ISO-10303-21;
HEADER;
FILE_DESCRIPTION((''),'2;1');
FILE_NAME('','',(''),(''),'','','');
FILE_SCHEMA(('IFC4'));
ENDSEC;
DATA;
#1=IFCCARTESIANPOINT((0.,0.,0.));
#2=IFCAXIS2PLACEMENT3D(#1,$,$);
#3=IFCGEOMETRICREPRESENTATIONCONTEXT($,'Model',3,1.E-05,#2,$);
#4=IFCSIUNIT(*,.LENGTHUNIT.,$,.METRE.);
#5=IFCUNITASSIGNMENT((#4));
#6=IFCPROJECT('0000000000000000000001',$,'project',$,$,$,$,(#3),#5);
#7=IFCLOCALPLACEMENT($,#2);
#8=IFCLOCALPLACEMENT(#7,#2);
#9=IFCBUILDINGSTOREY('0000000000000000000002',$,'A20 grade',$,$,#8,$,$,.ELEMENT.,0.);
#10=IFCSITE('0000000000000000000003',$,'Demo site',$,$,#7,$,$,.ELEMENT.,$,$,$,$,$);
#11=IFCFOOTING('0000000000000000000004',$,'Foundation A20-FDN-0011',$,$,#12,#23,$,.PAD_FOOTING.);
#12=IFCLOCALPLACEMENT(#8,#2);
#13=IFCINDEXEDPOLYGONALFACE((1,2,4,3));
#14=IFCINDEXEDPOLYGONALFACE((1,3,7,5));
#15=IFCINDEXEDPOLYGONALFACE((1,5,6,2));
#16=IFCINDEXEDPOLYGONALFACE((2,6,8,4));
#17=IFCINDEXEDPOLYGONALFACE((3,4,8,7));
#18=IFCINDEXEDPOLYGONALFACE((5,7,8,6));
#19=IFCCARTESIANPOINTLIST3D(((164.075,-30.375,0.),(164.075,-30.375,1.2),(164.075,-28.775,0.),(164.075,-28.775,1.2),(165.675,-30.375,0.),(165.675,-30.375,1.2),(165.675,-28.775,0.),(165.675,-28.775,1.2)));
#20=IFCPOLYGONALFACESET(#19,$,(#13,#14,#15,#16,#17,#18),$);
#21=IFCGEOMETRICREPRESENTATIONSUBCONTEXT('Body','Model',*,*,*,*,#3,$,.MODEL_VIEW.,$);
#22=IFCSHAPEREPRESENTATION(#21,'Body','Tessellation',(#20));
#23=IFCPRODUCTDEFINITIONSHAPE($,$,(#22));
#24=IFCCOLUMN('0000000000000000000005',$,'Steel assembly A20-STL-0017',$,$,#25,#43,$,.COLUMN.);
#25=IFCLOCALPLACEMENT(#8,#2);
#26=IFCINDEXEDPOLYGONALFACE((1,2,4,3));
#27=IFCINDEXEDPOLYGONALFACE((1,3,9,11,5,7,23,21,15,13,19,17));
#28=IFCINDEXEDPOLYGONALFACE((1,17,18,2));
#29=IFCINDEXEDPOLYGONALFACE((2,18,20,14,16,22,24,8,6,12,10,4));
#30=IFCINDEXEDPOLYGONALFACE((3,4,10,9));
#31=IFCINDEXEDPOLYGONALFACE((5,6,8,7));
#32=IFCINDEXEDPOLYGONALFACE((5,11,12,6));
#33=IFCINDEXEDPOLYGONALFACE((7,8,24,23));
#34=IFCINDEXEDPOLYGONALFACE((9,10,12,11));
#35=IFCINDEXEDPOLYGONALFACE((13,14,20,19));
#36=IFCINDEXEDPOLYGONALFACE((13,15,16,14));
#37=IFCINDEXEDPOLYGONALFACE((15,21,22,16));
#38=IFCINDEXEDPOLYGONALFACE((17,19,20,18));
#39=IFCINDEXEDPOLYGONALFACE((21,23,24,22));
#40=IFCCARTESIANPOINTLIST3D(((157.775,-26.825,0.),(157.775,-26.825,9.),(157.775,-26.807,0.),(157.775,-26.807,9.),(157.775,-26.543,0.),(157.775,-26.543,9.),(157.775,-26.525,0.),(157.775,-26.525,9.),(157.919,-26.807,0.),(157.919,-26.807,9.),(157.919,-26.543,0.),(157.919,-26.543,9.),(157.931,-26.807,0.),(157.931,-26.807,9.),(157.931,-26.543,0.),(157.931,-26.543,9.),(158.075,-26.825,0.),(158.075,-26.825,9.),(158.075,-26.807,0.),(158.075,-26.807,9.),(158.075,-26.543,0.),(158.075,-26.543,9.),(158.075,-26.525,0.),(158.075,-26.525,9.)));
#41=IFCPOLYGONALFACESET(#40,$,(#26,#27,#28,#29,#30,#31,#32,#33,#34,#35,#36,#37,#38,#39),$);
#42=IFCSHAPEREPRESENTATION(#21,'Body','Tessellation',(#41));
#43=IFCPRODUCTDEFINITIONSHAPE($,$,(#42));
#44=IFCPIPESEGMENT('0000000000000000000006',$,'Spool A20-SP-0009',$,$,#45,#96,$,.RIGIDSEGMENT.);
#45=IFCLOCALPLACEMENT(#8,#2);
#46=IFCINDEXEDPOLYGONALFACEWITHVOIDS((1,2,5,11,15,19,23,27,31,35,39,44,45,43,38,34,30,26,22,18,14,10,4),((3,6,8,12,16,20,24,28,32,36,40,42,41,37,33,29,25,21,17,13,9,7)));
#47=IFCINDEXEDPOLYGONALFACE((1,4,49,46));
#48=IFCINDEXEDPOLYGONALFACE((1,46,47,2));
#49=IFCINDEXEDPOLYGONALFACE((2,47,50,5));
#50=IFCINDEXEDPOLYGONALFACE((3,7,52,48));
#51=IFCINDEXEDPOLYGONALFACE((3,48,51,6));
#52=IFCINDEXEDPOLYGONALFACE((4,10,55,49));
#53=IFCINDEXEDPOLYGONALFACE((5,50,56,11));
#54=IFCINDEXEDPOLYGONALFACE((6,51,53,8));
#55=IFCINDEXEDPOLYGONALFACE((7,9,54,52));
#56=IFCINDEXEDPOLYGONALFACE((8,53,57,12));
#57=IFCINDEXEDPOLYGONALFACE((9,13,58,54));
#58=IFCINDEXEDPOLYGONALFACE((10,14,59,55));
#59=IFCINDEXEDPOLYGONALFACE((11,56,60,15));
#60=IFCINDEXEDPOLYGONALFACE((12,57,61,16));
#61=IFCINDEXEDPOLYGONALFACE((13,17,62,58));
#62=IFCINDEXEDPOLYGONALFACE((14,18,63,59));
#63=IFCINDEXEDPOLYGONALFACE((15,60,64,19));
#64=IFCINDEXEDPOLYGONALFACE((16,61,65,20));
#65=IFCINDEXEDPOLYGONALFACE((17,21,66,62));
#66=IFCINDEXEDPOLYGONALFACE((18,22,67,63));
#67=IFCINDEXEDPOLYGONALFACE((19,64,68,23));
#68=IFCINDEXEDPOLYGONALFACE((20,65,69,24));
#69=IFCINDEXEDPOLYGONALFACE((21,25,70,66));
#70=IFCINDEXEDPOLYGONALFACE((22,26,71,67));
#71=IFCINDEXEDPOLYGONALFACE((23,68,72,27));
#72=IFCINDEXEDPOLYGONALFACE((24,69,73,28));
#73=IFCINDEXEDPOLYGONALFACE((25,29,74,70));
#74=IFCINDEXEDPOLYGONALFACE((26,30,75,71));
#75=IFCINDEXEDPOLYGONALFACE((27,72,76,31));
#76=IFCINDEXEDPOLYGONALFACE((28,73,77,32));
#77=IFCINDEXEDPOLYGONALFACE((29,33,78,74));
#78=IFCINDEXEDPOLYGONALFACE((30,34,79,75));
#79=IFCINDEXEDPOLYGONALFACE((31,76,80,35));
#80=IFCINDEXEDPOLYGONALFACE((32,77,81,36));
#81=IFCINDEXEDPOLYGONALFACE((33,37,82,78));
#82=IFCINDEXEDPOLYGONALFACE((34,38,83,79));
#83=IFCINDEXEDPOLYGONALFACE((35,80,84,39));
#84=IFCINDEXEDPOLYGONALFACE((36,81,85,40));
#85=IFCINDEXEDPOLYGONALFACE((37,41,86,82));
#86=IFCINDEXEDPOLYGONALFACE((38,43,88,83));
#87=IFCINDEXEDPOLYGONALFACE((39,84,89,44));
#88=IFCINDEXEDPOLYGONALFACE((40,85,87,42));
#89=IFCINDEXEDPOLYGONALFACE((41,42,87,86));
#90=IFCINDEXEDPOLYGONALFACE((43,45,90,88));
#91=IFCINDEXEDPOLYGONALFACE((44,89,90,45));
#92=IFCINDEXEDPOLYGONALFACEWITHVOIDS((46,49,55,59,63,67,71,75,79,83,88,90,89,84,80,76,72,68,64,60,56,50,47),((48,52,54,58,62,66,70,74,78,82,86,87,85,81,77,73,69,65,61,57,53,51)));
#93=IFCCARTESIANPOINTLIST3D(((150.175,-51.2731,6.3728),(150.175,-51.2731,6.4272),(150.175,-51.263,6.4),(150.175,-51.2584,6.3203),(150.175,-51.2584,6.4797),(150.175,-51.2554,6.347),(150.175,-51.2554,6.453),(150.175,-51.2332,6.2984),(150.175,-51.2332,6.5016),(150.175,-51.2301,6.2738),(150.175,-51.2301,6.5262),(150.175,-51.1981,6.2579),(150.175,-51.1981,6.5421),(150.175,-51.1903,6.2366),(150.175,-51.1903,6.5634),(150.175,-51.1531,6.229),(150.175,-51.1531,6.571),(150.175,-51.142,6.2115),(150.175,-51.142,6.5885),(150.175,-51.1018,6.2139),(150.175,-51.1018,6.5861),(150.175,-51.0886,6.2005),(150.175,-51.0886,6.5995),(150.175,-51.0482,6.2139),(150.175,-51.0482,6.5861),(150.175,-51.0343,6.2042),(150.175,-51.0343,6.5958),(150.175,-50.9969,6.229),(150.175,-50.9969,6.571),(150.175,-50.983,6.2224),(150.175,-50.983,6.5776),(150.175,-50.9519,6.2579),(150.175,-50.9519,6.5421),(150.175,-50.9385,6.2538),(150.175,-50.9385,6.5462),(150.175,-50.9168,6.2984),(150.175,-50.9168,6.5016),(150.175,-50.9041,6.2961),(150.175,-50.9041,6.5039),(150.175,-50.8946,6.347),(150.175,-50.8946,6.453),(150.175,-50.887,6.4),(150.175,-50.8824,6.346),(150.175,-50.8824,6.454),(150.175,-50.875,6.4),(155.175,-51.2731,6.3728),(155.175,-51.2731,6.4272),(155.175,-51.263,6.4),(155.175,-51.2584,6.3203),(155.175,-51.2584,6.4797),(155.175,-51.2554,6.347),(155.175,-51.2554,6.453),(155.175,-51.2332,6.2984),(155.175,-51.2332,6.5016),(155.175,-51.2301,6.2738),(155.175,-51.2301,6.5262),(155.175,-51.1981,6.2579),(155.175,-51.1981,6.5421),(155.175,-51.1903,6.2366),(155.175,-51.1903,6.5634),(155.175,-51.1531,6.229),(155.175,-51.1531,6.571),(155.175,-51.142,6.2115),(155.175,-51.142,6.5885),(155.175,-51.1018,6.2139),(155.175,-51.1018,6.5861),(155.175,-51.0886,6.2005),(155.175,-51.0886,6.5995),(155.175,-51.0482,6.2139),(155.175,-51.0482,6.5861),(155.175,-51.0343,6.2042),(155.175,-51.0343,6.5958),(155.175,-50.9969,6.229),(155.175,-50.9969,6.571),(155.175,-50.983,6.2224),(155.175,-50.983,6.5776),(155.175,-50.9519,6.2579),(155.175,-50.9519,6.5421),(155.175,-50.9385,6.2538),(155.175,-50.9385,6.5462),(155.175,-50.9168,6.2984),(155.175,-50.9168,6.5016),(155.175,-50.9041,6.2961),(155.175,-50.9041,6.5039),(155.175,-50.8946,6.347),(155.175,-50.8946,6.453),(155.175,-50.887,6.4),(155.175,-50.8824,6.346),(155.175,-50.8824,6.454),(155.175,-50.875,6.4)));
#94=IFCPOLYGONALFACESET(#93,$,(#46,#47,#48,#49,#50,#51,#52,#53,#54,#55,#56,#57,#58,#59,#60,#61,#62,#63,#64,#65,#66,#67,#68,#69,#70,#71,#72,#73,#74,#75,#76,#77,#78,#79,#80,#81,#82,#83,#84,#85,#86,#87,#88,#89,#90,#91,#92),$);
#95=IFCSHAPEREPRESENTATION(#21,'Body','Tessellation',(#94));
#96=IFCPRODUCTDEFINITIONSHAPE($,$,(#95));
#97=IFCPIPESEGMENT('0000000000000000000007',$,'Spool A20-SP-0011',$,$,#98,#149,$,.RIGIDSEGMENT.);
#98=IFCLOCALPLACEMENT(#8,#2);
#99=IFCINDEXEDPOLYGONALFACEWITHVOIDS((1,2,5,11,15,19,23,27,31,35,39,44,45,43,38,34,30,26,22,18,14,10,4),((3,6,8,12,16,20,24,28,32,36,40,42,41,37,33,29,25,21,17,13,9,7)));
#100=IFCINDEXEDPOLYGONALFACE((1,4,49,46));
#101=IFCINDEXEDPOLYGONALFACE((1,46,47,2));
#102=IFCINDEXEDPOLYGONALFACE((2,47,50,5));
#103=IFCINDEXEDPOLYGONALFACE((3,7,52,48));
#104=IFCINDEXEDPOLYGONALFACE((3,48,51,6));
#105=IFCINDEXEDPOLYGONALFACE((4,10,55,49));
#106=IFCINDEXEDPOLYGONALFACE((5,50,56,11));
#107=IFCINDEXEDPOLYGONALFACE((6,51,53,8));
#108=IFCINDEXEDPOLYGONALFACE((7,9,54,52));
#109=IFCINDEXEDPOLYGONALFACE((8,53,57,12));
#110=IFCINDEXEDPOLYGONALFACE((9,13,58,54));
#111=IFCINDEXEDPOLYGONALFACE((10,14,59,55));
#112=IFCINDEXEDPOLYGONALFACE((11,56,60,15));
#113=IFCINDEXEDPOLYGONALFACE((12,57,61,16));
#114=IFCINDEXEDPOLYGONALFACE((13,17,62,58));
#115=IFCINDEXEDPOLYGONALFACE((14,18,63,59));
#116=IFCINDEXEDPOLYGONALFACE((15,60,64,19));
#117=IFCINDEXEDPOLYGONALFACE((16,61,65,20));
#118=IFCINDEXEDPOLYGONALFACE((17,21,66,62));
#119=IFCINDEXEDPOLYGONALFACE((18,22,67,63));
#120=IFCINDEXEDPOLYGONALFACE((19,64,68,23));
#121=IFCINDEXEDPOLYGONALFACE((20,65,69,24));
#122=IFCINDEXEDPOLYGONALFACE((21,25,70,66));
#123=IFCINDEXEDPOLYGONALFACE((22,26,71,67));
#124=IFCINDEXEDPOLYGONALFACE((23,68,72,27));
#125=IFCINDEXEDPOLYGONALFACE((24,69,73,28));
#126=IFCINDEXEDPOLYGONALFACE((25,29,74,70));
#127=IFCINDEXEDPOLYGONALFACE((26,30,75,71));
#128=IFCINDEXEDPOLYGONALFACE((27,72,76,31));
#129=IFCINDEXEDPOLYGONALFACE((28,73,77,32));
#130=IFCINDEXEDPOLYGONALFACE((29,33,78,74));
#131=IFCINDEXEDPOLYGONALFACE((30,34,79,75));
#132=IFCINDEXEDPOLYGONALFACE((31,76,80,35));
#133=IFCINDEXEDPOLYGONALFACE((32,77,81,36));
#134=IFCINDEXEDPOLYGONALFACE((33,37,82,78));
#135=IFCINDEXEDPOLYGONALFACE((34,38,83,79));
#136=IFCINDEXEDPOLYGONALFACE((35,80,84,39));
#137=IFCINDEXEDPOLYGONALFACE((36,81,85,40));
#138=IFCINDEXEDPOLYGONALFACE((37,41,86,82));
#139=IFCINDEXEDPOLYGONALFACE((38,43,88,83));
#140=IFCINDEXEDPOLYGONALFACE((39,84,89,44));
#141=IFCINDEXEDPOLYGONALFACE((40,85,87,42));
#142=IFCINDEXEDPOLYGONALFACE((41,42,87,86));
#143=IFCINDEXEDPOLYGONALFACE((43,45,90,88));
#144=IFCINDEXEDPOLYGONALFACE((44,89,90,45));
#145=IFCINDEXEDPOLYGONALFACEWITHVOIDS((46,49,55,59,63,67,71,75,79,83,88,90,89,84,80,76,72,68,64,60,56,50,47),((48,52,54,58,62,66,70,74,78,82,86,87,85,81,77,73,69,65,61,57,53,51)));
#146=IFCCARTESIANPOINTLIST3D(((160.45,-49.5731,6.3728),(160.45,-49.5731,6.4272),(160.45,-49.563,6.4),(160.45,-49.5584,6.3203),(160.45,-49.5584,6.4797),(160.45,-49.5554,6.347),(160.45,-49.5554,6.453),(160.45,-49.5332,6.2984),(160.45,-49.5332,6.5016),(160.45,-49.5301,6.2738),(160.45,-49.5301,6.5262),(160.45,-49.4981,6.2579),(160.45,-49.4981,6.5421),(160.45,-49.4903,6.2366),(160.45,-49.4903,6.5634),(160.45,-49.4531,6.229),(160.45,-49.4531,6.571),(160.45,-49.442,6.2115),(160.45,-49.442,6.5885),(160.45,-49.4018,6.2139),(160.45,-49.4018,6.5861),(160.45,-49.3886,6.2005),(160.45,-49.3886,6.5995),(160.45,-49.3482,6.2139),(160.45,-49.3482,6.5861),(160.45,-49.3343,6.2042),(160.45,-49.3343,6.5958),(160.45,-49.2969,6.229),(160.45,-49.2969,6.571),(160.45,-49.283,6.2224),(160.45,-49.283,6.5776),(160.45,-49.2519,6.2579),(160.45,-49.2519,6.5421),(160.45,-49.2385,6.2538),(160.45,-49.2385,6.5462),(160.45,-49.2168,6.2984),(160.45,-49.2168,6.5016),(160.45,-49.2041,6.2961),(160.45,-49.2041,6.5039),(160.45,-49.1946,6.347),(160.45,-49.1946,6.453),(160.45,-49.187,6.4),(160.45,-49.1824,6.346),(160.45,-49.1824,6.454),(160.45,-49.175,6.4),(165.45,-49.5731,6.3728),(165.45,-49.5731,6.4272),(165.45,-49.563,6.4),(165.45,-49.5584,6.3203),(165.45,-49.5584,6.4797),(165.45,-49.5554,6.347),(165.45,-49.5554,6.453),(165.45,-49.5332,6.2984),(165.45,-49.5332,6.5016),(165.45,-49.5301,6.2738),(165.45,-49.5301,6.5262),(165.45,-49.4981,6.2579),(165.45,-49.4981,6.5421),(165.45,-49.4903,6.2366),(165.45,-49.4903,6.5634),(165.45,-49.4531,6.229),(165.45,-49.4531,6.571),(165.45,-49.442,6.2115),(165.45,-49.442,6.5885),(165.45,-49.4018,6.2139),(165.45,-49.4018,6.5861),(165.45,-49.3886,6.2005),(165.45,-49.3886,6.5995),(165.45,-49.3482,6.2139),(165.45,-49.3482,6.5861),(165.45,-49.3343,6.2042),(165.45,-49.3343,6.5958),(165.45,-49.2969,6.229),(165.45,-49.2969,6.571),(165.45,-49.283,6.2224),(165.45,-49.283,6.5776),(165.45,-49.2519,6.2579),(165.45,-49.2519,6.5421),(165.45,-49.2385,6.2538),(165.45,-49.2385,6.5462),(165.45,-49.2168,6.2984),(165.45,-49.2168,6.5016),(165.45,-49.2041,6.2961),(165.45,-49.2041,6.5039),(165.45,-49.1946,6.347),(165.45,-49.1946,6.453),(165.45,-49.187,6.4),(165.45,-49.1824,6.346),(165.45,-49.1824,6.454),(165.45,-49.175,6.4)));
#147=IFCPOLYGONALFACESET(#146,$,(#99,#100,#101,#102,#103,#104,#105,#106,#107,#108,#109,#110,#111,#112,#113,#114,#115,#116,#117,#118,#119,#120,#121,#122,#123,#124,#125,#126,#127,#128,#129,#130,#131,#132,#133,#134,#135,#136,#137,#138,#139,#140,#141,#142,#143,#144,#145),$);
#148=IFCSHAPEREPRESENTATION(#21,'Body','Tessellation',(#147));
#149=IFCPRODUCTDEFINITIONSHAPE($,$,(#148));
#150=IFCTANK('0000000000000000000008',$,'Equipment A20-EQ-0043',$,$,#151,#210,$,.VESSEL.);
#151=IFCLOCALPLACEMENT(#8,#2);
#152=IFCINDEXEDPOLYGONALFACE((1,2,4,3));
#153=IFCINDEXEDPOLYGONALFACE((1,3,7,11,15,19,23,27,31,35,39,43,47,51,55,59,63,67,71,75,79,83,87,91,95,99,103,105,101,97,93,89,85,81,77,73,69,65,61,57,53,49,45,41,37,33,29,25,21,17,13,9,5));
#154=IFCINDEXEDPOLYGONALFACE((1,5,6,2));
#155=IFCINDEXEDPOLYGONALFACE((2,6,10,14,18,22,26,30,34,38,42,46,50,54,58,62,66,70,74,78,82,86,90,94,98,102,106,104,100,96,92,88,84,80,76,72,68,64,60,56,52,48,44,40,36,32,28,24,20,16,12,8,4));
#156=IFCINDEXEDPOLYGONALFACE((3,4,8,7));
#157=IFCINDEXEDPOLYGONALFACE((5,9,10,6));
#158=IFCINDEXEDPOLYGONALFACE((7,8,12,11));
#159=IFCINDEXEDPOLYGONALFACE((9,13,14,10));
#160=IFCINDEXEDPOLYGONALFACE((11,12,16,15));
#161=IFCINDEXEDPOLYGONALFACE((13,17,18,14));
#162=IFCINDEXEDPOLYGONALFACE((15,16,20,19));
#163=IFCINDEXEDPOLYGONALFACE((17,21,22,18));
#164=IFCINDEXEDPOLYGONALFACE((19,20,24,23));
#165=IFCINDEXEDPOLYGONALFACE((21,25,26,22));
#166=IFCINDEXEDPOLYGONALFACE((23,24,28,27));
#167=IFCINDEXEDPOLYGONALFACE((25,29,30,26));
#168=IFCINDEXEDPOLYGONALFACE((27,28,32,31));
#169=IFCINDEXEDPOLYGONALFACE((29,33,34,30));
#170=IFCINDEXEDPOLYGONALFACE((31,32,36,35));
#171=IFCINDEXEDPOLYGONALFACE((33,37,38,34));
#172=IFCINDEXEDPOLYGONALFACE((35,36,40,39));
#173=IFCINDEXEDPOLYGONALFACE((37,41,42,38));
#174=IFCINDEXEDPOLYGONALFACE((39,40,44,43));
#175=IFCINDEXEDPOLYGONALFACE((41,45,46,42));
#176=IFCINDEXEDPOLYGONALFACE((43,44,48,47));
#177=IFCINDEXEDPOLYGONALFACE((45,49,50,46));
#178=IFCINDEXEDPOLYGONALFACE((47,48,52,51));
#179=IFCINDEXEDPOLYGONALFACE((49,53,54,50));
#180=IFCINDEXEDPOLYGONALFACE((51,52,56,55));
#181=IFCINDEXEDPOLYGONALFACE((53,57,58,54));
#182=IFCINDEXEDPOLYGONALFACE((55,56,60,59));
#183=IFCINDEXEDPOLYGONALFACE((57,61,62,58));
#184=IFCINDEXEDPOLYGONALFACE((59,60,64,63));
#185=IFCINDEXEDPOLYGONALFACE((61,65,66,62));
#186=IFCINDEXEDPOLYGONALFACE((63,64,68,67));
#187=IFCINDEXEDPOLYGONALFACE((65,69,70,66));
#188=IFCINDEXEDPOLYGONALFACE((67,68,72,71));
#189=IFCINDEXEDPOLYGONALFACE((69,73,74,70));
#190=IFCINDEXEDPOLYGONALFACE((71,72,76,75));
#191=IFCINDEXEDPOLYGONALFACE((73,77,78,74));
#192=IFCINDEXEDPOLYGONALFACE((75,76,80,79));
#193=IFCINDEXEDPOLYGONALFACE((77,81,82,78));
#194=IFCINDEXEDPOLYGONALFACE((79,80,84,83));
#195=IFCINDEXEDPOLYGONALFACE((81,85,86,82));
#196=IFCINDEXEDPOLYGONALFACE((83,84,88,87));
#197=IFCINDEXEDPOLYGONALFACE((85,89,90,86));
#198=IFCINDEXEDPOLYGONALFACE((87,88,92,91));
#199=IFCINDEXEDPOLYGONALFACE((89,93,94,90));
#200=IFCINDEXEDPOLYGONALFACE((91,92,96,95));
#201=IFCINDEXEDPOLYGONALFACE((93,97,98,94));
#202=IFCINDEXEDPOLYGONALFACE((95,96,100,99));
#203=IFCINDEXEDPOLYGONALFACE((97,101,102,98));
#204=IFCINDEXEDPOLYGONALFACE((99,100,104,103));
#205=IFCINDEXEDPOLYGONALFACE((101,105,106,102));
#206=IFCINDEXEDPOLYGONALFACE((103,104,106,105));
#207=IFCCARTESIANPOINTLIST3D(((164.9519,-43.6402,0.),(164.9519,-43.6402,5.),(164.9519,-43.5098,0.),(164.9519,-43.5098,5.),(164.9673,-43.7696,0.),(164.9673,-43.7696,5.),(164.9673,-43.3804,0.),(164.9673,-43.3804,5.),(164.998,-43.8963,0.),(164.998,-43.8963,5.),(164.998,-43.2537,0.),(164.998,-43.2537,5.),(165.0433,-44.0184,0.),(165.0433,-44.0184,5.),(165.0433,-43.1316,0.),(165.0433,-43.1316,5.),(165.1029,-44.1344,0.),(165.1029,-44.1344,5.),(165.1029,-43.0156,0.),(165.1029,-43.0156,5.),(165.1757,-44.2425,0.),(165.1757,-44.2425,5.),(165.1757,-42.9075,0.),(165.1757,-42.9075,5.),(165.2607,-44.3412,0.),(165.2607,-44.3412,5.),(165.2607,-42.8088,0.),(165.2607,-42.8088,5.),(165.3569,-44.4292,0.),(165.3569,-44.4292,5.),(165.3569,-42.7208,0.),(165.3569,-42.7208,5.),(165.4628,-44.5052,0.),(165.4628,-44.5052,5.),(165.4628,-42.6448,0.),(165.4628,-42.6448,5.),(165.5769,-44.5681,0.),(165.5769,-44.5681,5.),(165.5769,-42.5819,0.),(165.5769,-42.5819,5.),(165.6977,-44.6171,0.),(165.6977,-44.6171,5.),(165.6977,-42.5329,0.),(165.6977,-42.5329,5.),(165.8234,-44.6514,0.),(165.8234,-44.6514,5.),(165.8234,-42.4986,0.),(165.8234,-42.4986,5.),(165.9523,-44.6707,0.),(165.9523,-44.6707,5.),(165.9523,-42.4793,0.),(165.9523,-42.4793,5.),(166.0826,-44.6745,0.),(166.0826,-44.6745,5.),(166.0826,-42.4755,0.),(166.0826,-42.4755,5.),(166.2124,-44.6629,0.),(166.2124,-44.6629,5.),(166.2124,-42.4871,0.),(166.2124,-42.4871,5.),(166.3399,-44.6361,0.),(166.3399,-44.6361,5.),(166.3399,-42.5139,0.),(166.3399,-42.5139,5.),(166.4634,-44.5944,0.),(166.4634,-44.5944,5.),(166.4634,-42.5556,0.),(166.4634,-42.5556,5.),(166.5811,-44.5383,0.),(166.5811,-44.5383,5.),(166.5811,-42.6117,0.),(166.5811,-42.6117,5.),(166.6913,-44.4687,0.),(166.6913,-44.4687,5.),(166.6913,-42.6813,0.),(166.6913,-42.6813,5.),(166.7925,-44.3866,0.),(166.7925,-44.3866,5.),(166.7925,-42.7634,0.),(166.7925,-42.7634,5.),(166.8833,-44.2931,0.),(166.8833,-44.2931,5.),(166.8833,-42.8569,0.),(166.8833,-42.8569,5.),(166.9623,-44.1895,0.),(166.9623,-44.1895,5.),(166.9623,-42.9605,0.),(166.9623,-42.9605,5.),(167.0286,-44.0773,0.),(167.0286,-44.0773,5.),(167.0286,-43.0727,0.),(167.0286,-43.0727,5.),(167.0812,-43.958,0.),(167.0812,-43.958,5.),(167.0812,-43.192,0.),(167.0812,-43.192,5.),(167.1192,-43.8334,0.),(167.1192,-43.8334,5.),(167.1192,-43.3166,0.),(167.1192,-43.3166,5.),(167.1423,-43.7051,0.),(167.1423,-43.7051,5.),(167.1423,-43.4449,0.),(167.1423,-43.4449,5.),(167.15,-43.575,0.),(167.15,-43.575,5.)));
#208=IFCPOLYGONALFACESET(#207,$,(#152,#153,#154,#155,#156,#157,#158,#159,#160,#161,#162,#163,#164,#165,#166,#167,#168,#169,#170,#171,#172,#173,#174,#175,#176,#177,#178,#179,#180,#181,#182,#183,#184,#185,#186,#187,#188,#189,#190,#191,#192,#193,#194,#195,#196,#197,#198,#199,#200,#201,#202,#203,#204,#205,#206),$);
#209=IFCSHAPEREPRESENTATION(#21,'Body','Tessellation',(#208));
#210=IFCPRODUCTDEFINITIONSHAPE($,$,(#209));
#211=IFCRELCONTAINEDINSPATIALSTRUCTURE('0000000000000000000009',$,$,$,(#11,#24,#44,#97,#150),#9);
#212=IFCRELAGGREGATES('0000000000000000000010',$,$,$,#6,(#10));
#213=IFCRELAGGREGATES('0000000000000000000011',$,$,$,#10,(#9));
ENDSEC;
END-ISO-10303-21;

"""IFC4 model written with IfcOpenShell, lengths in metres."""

from ifc_helpers import new_model, si_unit, frame, origin, place, context, subcontext, project, spatial, rectangle, circle, hollow_circle, i_section, extrude, element, save


model = new_model("IFC4")

# Units and contexts
model_context = context("Model", 3, precision=1e-05, world=origin())
body_context = subcontext(model_context, "Body", "Model", "MODEL_VIEW")
ifc_project = project(units=[si_unit("LENGTHUNIT", "METRE")], contexts=[model_context])

# Site, storey
site_placement = place(None, origin())
site = spatial("IfcSite", under=ifc_project, at=site_placement, Name="Demo site", CompositionType="ELEMENT")
storey_placement = place(site_placement, origin())
storey = spatial("IfcBuildingStorey", under=site, at=storey_placement, Name="A20 grade", CompositionType="ELEMENT", Elevation=0.0)

# Footing
footing_placement = place(storey_placement, frame((164.875, -29.575, 0.0)))
element("IfcFooting", 1, at=footing_placement, inside=storey, Name="Foundation A20-FDN-0011", PredefinedType="PAD_FOOTING", context=body_context, shape_type="SweptSolid", body=[
    extrude(rectangle(XDim=1.6, YDim=1.6), origin(), (0.0, 0.0, 1.0), 1.2),
])

# Column
column_placement = place(storey_placement, frame((157.925, -26.675, 0.0)))
element("IfcColumn", 2, at=column_placement, inside=storey, Name="Steel assembly A20-STL-0017", PredefinedType="COLUMN", context=body_context, shape_type="SweptSolid", body=[
    extrude(i_section(OverallWidth=0.3, OverallDepth=0.3, WebThickness=0.012, FlangeThickness=0.018), origin(), (0.0, 0.0, 1.0), 9.0),
])

# Pipe segments
for number, where, name in (
    (3, (150.175, -51.075, 6.4), "Spool A20-SP-0009"),
    (4, (160.45, -49.375, 6.4), "Spool A20-SP-0011"),
):
    element("IfcPipeSegment", number, at=place(storey_placement, frame(where)), inside=storey, Name=name, PredefinedType="RIGIDSEGMENT", context=body_context, shape_type="SweptSolid", body=[
        extrude(hollow_circle(Radius=0.2, WallThickness=0.012), frame((0.0, 0.0, 0.0), z_axis=(1.0, 0.0, 0.0), x_axis=(0.0, 1.0, 0.0)), (0.0, 0.0, 1.0), 5.0),
    ])

# Tank
for number, where, name in (
    (5, (166.05, -43.575, 0.0), "Equipment A20-EQ-0043"),
):
    element("IfcTank", number, at=place(storey_placement, frame(where)), inside=storey, Name=name, PredefinedType="VESSEL", context=body_context, shape_type="SweptSolid", body=[
        extrude(circle(Radius=1.1), origin(), (0.0, 0.0, 1.0), 5.0),
    ])

save(model, "model.ifc")
